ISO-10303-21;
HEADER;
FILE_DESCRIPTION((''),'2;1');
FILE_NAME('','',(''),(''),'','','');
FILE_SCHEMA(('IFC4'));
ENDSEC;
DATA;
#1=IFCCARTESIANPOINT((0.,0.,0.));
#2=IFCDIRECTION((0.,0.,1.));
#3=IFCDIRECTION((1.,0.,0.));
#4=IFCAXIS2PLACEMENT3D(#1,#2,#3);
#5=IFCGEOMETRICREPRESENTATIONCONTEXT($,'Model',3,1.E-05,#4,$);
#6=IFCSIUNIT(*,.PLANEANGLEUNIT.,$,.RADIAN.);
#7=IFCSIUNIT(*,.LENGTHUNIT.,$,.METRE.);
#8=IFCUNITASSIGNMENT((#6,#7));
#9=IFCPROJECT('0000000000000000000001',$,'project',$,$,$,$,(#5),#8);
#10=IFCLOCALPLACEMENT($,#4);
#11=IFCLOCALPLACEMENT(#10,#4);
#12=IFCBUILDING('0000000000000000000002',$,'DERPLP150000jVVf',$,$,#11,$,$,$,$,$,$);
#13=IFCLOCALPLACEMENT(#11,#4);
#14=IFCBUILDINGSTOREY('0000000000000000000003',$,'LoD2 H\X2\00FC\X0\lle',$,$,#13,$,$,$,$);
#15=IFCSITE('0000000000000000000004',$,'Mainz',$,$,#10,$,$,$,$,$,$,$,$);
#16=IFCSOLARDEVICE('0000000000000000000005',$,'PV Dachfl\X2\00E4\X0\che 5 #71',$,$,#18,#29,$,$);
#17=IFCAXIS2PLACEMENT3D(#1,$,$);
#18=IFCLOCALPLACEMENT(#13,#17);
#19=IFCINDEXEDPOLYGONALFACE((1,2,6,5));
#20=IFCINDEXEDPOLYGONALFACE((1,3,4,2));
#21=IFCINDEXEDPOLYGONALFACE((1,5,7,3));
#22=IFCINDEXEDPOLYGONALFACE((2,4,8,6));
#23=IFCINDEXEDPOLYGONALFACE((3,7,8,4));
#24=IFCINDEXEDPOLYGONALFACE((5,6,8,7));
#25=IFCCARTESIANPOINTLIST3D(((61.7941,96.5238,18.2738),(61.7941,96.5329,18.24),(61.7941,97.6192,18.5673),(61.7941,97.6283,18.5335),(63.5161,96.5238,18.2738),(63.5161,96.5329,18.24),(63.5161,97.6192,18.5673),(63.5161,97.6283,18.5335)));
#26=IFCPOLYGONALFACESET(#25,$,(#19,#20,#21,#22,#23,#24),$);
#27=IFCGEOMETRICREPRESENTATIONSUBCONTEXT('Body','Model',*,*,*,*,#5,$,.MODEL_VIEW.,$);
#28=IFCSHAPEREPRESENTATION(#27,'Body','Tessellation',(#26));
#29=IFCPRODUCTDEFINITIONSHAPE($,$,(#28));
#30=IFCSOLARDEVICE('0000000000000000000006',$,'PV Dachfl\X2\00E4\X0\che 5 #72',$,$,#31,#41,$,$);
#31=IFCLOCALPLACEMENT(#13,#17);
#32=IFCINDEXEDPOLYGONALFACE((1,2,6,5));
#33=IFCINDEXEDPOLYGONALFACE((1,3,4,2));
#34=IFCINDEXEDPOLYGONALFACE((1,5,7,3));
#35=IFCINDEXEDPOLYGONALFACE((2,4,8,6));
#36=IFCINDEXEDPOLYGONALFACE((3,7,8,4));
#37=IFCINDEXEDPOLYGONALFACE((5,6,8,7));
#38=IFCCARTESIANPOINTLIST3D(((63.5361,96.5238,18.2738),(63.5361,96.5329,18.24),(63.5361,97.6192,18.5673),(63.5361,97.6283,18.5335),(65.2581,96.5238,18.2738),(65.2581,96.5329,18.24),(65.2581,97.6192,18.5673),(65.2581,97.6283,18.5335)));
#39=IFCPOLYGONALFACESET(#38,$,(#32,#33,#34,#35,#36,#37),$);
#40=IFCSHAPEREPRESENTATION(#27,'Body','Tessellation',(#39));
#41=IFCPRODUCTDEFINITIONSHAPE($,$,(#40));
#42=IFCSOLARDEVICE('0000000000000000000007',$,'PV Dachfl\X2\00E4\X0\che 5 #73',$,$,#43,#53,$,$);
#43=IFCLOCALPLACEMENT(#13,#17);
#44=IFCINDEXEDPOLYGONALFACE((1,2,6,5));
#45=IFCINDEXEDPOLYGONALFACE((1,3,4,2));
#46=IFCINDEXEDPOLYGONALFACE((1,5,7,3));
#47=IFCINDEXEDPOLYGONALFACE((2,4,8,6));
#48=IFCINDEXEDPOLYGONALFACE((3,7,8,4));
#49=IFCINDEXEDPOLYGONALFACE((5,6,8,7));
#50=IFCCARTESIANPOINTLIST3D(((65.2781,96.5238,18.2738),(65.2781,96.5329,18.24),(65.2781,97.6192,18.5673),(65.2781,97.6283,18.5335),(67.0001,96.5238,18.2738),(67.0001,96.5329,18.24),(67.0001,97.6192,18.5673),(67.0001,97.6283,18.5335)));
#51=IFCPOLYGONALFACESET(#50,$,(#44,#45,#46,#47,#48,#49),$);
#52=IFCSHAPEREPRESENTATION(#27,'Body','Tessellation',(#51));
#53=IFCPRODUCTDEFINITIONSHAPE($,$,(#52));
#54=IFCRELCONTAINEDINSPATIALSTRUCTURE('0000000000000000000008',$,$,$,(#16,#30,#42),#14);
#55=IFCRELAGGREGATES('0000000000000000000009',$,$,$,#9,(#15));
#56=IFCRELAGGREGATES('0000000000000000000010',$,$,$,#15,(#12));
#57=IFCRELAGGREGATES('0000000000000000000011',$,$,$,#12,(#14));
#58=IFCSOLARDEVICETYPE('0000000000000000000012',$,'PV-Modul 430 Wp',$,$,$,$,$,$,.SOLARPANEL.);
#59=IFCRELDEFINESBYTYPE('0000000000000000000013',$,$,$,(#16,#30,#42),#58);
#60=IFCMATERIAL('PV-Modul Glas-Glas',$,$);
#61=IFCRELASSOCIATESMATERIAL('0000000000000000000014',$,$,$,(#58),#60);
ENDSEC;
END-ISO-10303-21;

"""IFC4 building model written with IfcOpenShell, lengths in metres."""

from ifc_helpers import new_model, si_unit, frame, frame_2d, origin, origin_with_axes, place, context, subcontext, project, spatial, rectangle, extrude, source, transform, mapped, material, type_object, type_shapes, element, save


model = new_model("IFC4")

# Units and contexts
model_context = context("Model", 3, precision=1e-05, world=origin_with_axes())
body_context = subcontext(model_context, "Body", "Model", "MODEL_VIEW")
ifc_project = project(units=[si_unit("PLANEANGLEUNIT", "RADIAN"), si_unit("LENGTHUNIT", "METRE")], contexts=[model_context])

# Site, building, storey
site_placement = place(None, origin_with_axes())
site = spatial("IfcSite", under=ifc_project, at=site_placement, Name="Mainz")
building_placement = place(site_placement, origin_with_axes())
building = spatial("IfcBuilding", under=site, at=building_placement, Name="DERPLP150000jVVf")
storey_placement = place(building_placement, origin_with_axes())
storey = spatial("IfcBuildingStorey", under=building, at=storey_placement, Name="LoD2 Hülle")

# Solar devices
ifc_material = material(Name="PV-Modul Glas-Glas")
solar_device_type = type_object("IfcSolarDeviceType", Name="PV-Modul 430 Wp", PredefinedType="SOLARPANEL", material=ifc_material)
shared_shape = source(origin_with_axes(), body_context, "Body", "SweptSolid", [
    extrude(rectangle(XDim=1.722, YDim=1.134, at=frame_2d((0.861, 0.567))), origin(), (0.0, 0.0, 1.0), 0.035),
])
type_shapes(solar_device_type, [shared_shape])
for number, where, z_axis, x_axis, name in (
    (1, (61.7941, 96.5329, 18.24), (0.0, -0.258819, 0.965926), (1.0, 0.0, 0.0), "PV Dachfläche 5 #71"),
    (2, (63.5361, 96.5329, 18.24), (0.0, -0.258819, 0.965926), (1.0, 0.0, 0.0), "PV Dachfläche 5 #72"),
    (3, (65.2781, 96.5329, 18.24), (0.0, -0.258819, 0.965926), (1.0, 0.0, 0.0), "PV Dachfläche 5 #73"),
):
    element("IfcSolarDevice", number, at=place(storey_placement, frame(where, z_axis=z_axis, x_axis=x_axis)), inside=storey, type_object=solar_device_type, Name=name, context=body_context, shape_type="MappedRepresentation", body=[
        mapped(shared_shape, transform((0.0, 0.0, 0.0), x_axis=(1.0, 0.0, 0.0), y_axis=(0.0, 1.0, 0.0), z_axis=(0.0, 0.0, 1.0), scale=1.0)),
    ])

save(model, "model.ifc")
